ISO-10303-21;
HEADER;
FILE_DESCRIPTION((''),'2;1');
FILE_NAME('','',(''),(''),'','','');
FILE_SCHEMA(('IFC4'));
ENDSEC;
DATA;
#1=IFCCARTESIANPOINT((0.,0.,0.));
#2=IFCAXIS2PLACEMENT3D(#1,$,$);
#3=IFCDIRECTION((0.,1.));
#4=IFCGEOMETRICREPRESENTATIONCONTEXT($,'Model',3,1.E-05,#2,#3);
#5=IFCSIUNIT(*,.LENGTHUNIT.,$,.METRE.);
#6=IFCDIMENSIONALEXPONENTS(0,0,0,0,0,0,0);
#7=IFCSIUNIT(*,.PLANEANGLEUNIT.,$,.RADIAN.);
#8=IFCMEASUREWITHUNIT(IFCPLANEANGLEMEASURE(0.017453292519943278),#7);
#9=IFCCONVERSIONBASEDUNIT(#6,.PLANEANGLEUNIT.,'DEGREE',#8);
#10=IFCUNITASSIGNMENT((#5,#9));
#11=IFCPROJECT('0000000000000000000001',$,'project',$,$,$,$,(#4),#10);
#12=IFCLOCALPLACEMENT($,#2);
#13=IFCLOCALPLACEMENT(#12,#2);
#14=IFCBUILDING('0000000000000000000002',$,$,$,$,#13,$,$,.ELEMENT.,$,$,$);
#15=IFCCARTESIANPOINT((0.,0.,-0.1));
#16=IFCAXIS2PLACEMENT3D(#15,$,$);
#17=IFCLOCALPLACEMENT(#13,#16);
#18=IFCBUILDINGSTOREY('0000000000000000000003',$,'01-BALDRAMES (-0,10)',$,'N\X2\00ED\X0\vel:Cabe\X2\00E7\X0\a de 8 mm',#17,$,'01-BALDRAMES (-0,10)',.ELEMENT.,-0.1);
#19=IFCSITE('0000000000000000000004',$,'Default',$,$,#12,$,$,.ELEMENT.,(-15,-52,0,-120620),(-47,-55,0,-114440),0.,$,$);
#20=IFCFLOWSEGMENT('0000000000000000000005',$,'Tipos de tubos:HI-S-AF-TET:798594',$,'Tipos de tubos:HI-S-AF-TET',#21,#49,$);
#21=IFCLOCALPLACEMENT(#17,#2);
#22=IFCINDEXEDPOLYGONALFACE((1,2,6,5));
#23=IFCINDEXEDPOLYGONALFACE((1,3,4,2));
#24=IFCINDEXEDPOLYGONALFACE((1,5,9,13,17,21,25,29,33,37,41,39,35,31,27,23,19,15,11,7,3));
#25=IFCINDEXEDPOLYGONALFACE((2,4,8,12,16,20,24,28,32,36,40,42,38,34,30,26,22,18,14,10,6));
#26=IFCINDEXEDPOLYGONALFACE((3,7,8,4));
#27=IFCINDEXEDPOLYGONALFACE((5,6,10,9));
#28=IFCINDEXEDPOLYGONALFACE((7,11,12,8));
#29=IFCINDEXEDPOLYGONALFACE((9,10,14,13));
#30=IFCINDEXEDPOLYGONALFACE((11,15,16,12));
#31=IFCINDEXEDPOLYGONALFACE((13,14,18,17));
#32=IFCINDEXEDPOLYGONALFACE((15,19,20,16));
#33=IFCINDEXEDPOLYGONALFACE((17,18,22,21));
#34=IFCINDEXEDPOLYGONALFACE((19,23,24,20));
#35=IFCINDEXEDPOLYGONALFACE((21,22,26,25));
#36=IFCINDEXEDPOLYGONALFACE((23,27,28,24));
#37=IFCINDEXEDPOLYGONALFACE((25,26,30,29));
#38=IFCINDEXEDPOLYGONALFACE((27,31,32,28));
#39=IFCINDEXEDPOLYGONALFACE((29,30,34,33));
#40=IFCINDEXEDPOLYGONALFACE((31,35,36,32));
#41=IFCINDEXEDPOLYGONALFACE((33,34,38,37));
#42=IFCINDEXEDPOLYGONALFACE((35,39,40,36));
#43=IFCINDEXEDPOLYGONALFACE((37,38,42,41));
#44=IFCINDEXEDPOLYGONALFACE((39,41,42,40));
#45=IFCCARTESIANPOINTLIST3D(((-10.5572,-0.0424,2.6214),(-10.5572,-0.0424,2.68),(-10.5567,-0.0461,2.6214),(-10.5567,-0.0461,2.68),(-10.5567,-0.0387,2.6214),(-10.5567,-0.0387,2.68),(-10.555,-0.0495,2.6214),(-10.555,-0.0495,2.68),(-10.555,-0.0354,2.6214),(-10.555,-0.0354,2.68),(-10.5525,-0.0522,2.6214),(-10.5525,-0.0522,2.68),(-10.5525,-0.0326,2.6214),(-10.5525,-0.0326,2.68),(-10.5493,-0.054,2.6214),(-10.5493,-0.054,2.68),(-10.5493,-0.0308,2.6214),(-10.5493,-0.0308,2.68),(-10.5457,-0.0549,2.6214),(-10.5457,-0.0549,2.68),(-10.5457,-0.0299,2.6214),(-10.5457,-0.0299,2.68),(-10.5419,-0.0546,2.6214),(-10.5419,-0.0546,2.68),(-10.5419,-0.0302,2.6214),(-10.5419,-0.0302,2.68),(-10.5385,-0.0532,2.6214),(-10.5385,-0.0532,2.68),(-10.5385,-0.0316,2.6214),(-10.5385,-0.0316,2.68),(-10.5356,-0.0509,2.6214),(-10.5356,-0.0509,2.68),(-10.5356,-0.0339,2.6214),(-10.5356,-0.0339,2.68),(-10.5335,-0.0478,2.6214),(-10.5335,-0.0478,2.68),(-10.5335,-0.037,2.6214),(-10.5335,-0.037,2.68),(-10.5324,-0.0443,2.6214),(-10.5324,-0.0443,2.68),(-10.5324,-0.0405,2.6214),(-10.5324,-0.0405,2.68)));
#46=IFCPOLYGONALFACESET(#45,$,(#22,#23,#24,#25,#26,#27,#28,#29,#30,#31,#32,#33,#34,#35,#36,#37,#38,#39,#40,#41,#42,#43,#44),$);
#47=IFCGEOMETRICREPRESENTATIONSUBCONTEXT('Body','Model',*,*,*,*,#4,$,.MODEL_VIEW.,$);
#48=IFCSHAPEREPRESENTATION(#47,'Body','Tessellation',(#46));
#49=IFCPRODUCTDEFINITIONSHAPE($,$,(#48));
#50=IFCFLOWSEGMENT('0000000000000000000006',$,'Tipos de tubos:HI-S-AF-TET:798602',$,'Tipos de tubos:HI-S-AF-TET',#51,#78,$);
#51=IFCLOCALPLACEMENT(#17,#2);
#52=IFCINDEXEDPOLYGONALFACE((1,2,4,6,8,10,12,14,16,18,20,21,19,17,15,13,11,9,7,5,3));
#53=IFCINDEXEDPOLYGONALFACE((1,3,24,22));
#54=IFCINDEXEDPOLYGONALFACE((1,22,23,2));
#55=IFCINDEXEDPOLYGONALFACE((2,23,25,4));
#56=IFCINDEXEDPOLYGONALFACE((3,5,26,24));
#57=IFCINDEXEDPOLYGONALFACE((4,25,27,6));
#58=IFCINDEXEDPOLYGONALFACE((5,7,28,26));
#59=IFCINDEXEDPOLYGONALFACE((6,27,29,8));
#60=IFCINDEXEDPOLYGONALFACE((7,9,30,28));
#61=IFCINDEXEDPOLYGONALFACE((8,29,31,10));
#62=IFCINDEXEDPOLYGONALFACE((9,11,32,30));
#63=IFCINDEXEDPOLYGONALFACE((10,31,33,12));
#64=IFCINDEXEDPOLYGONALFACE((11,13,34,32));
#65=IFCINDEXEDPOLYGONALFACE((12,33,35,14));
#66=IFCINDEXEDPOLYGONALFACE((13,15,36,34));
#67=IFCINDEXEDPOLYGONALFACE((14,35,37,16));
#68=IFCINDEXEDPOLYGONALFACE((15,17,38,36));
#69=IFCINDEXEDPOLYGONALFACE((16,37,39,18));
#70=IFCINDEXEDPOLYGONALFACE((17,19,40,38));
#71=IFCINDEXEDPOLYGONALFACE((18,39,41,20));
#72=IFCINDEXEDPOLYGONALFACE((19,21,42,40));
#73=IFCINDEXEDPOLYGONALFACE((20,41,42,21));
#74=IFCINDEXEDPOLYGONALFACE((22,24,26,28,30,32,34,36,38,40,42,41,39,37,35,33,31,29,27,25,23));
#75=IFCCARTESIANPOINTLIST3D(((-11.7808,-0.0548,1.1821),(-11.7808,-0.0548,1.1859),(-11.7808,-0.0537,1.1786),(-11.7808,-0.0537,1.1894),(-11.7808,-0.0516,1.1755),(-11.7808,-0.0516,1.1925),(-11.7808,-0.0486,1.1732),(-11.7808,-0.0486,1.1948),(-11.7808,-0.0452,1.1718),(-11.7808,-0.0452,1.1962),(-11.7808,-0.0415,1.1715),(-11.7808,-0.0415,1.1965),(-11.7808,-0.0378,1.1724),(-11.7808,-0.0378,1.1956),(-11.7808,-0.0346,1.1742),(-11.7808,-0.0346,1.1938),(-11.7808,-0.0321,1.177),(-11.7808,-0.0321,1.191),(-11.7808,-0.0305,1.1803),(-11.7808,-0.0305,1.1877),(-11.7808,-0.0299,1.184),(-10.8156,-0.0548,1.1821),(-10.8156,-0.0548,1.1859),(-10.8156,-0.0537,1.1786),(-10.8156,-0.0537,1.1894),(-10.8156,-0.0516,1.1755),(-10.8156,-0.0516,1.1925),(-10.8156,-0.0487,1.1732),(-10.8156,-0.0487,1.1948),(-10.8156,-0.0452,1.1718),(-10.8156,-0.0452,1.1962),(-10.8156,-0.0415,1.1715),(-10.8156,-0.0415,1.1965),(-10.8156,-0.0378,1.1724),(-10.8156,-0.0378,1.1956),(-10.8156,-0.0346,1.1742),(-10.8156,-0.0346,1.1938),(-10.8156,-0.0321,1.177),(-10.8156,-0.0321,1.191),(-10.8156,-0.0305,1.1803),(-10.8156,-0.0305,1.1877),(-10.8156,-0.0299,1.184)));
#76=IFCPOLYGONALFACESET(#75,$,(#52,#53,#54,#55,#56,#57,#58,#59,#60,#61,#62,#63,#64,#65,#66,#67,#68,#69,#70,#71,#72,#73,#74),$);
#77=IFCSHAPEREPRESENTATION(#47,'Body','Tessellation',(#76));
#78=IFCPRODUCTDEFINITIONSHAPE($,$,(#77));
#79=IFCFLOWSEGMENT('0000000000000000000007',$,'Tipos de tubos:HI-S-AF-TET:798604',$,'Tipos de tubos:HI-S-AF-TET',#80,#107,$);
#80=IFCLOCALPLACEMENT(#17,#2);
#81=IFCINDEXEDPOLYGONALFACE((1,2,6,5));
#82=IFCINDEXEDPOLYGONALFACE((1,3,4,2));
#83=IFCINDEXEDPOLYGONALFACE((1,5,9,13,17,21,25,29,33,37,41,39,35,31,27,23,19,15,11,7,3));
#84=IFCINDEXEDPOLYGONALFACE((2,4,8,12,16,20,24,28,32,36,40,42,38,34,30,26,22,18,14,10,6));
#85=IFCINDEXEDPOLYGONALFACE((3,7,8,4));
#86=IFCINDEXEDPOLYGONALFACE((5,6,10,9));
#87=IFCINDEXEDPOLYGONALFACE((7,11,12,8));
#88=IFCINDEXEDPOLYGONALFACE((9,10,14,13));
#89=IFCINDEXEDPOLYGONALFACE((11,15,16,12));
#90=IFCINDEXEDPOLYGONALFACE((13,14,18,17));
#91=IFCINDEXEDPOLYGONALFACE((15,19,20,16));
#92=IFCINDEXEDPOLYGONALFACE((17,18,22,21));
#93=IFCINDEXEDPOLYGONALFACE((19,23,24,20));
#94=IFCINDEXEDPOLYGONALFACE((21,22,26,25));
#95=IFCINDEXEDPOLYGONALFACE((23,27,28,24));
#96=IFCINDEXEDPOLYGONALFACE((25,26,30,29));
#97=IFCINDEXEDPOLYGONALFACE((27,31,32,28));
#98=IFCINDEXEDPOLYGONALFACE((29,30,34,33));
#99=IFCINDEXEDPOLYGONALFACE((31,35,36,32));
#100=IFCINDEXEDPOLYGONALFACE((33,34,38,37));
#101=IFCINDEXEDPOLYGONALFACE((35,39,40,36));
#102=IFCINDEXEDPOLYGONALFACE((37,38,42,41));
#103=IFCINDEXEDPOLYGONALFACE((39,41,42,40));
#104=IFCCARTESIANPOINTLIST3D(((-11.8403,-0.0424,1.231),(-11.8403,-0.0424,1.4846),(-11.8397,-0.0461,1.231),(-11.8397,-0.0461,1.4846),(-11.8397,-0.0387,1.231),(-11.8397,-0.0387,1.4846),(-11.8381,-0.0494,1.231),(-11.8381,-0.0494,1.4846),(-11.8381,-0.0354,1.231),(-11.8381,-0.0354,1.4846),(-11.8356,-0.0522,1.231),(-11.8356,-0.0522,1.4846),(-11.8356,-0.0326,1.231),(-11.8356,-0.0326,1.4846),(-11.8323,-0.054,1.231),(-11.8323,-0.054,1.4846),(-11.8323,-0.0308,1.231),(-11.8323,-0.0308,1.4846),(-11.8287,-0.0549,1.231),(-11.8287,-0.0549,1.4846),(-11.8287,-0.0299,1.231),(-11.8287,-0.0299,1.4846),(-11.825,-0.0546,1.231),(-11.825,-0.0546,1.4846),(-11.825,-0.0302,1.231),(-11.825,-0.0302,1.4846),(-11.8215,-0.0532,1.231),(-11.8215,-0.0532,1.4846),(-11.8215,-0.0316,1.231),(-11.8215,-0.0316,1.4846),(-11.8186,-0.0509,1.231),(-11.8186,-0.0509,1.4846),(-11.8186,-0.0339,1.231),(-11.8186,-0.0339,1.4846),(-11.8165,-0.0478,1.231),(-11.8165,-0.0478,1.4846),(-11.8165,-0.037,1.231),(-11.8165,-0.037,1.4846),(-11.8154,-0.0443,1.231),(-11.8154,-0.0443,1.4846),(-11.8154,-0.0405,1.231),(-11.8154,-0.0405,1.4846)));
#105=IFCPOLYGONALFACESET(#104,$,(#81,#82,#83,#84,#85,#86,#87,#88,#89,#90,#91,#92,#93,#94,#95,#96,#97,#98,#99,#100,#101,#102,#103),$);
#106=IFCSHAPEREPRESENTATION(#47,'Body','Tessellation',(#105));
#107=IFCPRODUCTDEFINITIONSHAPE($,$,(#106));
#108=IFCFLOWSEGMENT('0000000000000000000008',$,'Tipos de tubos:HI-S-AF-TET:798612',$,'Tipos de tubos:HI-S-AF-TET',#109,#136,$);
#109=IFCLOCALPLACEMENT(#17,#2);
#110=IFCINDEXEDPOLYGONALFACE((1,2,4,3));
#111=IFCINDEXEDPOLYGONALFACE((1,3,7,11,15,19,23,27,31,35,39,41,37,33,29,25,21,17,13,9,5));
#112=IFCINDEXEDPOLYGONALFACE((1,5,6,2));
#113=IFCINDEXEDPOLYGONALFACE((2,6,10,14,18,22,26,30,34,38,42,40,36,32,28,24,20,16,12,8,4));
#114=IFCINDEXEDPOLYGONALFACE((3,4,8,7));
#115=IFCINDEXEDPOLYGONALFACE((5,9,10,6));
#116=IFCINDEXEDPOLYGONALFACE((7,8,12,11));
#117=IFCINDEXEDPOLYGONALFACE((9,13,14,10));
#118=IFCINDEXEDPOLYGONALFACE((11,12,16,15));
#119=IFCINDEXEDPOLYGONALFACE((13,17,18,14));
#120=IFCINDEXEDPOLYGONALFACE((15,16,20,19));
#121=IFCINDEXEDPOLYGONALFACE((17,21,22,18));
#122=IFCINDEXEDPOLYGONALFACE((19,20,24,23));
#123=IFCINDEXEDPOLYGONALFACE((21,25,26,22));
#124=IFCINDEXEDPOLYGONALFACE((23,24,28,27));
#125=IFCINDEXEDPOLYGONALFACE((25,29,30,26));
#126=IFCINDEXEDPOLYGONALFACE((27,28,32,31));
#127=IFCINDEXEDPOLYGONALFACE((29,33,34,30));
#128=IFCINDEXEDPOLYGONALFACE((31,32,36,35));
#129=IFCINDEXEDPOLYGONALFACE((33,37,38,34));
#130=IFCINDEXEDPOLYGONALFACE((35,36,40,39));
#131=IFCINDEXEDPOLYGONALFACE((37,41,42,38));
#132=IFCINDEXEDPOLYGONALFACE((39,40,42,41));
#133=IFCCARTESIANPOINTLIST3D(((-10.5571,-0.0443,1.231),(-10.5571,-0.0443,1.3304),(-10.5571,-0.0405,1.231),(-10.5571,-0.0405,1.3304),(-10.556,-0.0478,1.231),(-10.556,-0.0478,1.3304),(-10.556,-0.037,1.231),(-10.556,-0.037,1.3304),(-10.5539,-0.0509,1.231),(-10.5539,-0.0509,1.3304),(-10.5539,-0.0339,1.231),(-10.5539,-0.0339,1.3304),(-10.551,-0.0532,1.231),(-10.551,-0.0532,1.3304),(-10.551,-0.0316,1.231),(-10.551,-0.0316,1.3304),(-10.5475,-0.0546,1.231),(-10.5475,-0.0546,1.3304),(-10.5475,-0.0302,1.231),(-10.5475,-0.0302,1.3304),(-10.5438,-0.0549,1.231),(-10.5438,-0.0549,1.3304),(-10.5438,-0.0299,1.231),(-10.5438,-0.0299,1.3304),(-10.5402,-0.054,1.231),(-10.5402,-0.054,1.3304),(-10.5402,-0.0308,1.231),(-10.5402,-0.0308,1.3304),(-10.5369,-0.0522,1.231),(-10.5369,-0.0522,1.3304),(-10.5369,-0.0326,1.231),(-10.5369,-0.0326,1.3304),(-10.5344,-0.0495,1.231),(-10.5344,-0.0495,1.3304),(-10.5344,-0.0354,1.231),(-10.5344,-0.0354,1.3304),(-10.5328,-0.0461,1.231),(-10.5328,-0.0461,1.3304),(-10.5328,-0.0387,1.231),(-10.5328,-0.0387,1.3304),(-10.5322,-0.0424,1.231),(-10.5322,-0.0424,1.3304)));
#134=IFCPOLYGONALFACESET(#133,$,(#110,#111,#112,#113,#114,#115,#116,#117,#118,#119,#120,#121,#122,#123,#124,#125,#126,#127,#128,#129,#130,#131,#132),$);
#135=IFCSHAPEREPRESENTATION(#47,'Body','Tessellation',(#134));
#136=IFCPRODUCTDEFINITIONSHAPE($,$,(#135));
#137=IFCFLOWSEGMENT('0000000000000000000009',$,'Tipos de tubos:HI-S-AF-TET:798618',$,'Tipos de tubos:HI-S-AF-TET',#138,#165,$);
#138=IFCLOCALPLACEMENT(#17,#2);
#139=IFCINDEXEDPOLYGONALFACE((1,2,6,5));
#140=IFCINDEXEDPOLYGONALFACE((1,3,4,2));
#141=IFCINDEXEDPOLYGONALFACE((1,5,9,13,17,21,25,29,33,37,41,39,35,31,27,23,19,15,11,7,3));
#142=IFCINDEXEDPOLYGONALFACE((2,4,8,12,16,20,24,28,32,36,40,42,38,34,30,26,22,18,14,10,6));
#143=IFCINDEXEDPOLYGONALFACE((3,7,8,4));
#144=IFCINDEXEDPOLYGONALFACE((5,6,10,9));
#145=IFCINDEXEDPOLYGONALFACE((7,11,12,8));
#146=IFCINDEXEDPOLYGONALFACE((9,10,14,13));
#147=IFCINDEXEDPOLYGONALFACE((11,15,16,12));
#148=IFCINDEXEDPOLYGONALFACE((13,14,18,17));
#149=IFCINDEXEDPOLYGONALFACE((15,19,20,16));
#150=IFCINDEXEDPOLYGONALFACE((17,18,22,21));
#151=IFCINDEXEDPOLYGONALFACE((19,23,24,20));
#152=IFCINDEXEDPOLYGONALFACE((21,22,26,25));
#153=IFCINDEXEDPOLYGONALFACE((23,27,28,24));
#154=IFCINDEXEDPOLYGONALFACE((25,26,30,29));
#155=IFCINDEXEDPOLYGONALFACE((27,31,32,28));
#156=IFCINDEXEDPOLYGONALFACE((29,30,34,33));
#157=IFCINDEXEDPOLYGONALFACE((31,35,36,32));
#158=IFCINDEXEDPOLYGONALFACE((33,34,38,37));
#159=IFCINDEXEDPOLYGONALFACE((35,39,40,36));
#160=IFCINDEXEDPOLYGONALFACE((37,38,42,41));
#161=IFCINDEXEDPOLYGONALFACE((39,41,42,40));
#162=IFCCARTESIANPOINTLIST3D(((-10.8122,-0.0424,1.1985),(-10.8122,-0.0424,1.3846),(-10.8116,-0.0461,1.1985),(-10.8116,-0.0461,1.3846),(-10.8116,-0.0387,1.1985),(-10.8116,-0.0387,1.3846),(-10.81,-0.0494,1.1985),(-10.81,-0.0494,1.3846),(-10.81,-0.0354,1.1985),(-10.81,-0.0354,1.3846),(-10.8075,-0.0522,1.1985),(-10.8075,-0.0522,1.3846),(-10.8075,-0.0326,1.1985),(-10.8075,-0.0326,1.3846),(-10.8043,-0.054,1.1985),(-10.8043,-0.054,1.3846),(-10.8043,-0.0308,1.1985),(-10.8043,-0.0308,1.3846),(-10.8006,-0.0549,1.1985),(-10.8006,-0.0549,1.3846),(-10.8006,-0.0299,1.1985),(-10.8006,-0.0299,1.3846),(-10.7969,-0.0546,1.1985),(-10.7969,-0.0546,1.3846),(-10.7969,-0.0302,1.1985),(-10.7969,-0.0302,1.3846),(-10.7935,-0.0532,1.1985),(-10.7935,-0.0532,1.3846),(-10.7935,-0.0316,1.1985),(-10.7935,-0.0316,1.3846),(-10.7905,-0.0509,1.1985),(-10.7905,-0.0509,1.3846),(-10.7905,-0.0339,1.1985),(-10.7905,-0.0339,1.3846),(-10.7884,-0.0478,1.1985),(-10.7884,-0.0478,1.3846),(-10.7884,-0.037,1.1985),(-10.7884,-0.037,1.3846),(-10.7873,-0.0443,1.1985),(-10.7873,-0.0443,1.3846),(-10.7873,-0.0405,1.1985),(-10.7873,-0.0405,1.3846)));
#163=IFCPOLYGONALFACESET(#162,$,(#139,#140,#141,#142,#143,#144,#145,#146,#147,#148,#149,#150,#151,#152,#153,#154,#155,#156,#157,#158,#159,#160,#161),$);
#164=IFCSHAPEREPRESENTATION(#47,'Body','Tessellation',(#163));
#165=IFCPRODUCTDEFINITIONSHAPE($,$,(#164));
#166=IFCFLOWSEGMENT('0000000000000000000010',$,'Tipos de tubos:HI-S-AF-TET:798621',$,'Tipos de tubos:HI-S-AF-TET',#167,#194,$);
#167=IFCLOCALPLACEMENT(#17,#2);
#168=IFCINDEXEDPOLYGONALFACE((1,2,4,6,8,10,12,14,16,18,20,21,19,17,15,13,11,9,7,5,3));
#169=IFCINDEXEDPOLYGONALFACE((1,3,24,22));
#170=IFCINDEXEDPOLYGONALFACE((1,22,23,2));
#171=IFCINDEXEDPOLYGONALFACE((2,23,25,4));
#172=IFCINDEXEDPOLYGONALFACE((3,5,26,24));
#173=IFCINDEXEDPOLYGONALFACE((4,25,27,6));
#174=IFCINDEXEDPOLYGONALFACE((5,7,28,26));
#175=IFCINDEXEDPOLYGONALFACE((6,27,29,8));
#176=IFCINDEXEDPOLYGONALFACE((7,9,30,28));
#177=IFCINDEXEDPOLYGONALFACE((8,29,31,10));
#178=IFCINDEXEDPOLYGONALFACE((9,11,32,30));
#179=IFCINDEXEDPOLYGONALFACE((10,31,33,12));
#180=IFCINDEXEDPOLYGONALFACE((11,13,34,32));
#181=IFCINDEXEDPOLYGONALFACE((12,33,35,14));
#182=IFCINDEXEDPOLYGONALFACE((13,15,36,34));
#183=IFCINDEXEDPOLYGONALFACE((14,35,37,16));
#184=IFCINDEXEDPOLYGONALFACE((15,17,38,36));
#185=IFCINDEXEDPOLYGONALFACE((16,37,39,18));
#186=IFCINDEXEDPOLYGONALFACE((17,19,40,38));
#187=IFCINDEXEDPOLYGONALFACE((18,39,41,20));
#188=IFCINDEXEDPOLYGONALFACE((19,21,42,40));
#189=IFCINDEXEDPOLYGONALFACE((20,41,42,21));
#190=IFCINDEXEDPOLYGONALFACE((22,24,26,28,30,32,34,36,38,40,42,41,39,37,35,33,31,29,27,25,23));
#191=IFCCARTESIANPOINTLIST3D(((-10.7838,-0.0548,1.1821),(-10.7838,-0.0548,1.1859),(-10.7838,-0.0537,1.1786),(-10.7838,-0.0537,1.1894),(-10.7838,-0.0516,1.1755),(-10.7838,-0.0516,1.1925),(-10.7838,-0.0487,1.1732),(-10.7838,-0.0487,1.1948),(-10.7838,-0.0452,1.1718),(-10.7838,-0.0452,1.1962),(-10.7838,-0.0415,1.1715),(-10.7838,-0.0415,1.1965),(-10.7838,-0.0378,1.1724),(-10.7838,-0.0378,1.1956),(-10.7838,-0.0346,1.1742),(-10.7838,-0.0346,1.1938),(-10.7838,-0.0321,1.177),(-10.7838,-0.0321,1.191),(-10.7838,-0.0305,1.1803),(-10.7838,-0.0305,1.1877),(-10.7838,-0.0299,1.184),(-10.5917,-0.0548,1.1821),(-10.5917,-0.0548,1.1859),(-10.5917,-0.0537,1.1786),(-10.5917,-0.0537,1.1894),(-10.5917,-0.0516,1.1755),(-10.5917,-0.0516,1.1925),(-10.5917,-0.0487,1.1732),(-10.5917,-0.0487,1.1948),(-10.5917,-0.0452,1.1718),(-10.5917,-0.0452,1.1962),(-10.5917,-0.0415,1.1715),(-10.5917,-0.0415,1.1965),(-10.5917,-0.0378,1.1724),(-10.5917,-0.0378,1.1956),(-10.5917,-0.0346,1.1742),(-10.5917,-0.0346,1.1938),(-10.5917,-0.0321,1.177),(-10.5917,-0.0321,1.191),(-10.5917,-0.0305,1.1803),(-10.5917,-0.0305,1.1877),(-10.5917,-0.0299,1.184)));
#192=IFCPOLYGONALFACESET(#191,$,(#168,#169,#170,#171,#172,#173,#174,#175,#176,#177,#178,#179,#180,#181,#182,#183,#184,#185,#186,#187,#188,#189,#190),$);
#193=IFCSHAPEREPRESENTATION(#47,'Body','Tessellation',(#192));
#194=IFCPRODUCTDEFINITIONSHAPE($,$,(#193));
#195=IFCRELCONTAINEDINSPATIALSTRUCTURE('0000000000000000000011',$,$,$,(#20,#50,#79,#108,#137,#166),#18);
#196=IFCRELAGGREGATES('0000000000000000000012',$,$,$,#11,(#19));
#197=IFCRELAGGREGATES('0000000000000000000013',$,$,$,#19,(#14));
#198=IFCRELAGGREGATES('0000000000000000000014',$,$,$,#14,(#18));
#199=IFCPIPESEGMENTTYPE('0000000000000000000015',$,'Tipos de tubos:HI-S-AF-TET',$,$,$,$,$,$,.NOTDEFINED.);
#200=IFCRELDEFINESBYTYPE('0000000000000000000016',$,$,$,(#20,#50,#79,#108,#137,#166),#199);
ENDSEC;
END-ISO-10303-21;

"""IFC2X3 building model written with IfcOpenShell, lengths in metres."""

from ifc_helpers import new_model, entity, si_unit, converted_unit, direction, frame, frame_2d, origin, place, context, subcontext, project, spatial, circle, extrude, type_object, element, save


model = new_model("IFC2X3")

# Units and contexts
model_context = context("Model", 3, precision=1e-05, world=origin(), true_north=direction((0.0, 1.0)))
body_context = subcontext(model_context, "Body", "Model", "MODEL_VIEW")
ifc_project = project(units=[si_unit("LENGTHUNIT", "METRE"), converted_unit("PLANEANGLEUNIT", "DEGREE", entity("IfcPlaneAngleMeasure", 0.017453292519943278), si_unit("PLANEANGLEUNIT", "RADIAN"), dimensions=[0, 0, 0, 0, 0, 0, 0])], contexts=[model_context])

# Site, building, storey
site_placement = place(None, origin())
site = spatial("IfcSite", under=ifc_project, at=site_placement, Name="Default", CompositionType="ELEMENT", RefLatitude=(-15, -52, 0, -120620), RefLongitude=(-47, -55, 0, -114440), RefElevation=0.0)
building_placement = place(site_placement, origin())
building = spatial("IfcBuilding", under=site, at=building_placement, CompositionType="ELEMENT")
storey_placement = place(building_placement, frame((0.0, 0.0, -0.1)))
storey = spatial("IfcBuildingStorey", under=building, at=storey_placement, Name="01-BALDRAMES (-0,10)", ObjectType="Nível:Cabeça de 8 mm", LongName="01-BALDRAMES (-0,10)", CompositionType="ELEMENT", Elevation=-0.1)

# Flow segments
pipe_segment_type_1 = type_object("IfcPipeSegmentType", Name="Tipos de tubos:HI-S-AF-TET", PredefinedType="NOTDEFINED")
flow_segment_1_placement = place(storey_placement, origin())
element("IfcFlowSegment", 1, at=flow_segment_1_placement, inside=storey, type_object=pipe_segment_type_1, Name="Tipos de tubos:HI-S-AF-TET:798594", ObjectType="Tipos de tubos:HI-S-AF-TET", context=body_context, shape_type="SweptSolid", body=[
    extrude(circle(Radius=0.0125, at=frame_2d((0.0, 0.0), x_axis=(1.0, 0.0))), frame((-10.5447, -0.0424, 2.6214), z_axis=(0.0, 0.0, 1.0), x_axis=(-1.0, 0.0, 0.0)), (0.0, 0.0, 1.0), 0.0586),
])
flow_segment_2_placement = place(storey_placement, origin())
element("IfcFlowSegment", 2, at=flow_segment_2_placement, inside=storey, type_object=pipe_segment_type_1, Name="Tipos de tubos:HI-S-AF-TET:798602", ObjectType="Tipos de tubos:HI-S-AF-TET", context=body_context, shape_type="SweptSolid", body=[
    extrude(circle(Radius=0.0125, at=frame_2d((0.0, 0.0), x_axis=(1.0, 0.0))), frame((-11.7808, -0.0424, 1.184), z_axis=(1.0, -0.000008, 0.0), x_axis=(0.000008, 1.0, 0.0)), (0.0, 0.0, 1.0), 0.9652),
])
flow_segment_3_placement = place(storey_placement, origin())
element("IfcFlowSegment", 3, at=flow_segment_3_placement, inside=storey, type_object=pipe_segment_type_1, Name="Tipos de tubos:HI-S-AF-TET:798604", ObjectType="Tipos de tubos:HI-S-AF-TET", context=body_context, shape_type="SweptSolid", body=[
    extrude(circle(Radius=0.0125, at=frame_2d((0.0, 0.0), x_axis=(1.0, 0.0))), frame((-11.8278, -0.0424, 1.231), z_axis=(0.0, 0.0, 1.0), x_axis=(-1.0, 0.0, 0.0)), (0.0, 0.0, 1.0), 0.2536),
])
flow_segment_4_placement = place(storey_placement, origin())
element("IfcFlowSegment", 4, at=flow_segment_4_placement, inside=storey, type_object=pipe_segment_type_1, Name="Tipos de tubos:HI-S-AF-TET:798612", ObjectType="Tipos de tubos:HI-S-AF-TET", context=body_context, shape_type="SweptSolid", body=[
    extrude(circle(Radius=0.0125, at=frame_2d((0.0, 0.0), x_axis=(1.0, 0.0))), frame((-10.5447, -0.0424, 1.231)), (0.0, 0.0, 1.0), 0.0994),
])
flow_segment_5_placement = place(storey_placement, origin())
element("IfcFlowSegment", 5, at=flow_segment_5_placement, inside=storey, type_object=pipe_segment_type_1, Name="Tipos de tubos:HI-S-AF-TET:798618", ObjectType="Tipos de tubos:HI-S-AF-TET", context=body_context, shape_type="SweptSolid", body=[
    extrude(circle(Radius=0.0125, at=frame_2d((0.0, 0.0), x_axis=(1.0, 0.0))), frame((-10.7997, -0.0424, 1.1985), z_axis=(0.0, 0.0, 1.0), x_axis=(-1.0, 0.0, 0.0)), (0.0, 0.0, 1.0), 0.1861),
])
flow_segment_6_placement = place(storey_placement, origin())
element("IfcFlowSegment", 6, at=flow_segment_6_placement, inside=storey, type_object=pipe_segment_type_1, Name="Tipos de tubos:HI-S-AF-TET:798621", ObjectType="Tipos de tubos:HI-S-AF-TET", context=body_context, shape_type="SweptSolid", body=[
    extrude(circle(Radius=0.0125, at=frame_2d((0.0, 0.0), x_axis=(1.0, 0.0))), frame((-10.7838, -0.0424, 1.184), z_axis=(1.0, -0.000007, 0.0), x_axis=(0.000007, 1.0, 0.0)), (0.0, 0.0, 1.0), 0.1921),
])

save(model, "model.ifc")
